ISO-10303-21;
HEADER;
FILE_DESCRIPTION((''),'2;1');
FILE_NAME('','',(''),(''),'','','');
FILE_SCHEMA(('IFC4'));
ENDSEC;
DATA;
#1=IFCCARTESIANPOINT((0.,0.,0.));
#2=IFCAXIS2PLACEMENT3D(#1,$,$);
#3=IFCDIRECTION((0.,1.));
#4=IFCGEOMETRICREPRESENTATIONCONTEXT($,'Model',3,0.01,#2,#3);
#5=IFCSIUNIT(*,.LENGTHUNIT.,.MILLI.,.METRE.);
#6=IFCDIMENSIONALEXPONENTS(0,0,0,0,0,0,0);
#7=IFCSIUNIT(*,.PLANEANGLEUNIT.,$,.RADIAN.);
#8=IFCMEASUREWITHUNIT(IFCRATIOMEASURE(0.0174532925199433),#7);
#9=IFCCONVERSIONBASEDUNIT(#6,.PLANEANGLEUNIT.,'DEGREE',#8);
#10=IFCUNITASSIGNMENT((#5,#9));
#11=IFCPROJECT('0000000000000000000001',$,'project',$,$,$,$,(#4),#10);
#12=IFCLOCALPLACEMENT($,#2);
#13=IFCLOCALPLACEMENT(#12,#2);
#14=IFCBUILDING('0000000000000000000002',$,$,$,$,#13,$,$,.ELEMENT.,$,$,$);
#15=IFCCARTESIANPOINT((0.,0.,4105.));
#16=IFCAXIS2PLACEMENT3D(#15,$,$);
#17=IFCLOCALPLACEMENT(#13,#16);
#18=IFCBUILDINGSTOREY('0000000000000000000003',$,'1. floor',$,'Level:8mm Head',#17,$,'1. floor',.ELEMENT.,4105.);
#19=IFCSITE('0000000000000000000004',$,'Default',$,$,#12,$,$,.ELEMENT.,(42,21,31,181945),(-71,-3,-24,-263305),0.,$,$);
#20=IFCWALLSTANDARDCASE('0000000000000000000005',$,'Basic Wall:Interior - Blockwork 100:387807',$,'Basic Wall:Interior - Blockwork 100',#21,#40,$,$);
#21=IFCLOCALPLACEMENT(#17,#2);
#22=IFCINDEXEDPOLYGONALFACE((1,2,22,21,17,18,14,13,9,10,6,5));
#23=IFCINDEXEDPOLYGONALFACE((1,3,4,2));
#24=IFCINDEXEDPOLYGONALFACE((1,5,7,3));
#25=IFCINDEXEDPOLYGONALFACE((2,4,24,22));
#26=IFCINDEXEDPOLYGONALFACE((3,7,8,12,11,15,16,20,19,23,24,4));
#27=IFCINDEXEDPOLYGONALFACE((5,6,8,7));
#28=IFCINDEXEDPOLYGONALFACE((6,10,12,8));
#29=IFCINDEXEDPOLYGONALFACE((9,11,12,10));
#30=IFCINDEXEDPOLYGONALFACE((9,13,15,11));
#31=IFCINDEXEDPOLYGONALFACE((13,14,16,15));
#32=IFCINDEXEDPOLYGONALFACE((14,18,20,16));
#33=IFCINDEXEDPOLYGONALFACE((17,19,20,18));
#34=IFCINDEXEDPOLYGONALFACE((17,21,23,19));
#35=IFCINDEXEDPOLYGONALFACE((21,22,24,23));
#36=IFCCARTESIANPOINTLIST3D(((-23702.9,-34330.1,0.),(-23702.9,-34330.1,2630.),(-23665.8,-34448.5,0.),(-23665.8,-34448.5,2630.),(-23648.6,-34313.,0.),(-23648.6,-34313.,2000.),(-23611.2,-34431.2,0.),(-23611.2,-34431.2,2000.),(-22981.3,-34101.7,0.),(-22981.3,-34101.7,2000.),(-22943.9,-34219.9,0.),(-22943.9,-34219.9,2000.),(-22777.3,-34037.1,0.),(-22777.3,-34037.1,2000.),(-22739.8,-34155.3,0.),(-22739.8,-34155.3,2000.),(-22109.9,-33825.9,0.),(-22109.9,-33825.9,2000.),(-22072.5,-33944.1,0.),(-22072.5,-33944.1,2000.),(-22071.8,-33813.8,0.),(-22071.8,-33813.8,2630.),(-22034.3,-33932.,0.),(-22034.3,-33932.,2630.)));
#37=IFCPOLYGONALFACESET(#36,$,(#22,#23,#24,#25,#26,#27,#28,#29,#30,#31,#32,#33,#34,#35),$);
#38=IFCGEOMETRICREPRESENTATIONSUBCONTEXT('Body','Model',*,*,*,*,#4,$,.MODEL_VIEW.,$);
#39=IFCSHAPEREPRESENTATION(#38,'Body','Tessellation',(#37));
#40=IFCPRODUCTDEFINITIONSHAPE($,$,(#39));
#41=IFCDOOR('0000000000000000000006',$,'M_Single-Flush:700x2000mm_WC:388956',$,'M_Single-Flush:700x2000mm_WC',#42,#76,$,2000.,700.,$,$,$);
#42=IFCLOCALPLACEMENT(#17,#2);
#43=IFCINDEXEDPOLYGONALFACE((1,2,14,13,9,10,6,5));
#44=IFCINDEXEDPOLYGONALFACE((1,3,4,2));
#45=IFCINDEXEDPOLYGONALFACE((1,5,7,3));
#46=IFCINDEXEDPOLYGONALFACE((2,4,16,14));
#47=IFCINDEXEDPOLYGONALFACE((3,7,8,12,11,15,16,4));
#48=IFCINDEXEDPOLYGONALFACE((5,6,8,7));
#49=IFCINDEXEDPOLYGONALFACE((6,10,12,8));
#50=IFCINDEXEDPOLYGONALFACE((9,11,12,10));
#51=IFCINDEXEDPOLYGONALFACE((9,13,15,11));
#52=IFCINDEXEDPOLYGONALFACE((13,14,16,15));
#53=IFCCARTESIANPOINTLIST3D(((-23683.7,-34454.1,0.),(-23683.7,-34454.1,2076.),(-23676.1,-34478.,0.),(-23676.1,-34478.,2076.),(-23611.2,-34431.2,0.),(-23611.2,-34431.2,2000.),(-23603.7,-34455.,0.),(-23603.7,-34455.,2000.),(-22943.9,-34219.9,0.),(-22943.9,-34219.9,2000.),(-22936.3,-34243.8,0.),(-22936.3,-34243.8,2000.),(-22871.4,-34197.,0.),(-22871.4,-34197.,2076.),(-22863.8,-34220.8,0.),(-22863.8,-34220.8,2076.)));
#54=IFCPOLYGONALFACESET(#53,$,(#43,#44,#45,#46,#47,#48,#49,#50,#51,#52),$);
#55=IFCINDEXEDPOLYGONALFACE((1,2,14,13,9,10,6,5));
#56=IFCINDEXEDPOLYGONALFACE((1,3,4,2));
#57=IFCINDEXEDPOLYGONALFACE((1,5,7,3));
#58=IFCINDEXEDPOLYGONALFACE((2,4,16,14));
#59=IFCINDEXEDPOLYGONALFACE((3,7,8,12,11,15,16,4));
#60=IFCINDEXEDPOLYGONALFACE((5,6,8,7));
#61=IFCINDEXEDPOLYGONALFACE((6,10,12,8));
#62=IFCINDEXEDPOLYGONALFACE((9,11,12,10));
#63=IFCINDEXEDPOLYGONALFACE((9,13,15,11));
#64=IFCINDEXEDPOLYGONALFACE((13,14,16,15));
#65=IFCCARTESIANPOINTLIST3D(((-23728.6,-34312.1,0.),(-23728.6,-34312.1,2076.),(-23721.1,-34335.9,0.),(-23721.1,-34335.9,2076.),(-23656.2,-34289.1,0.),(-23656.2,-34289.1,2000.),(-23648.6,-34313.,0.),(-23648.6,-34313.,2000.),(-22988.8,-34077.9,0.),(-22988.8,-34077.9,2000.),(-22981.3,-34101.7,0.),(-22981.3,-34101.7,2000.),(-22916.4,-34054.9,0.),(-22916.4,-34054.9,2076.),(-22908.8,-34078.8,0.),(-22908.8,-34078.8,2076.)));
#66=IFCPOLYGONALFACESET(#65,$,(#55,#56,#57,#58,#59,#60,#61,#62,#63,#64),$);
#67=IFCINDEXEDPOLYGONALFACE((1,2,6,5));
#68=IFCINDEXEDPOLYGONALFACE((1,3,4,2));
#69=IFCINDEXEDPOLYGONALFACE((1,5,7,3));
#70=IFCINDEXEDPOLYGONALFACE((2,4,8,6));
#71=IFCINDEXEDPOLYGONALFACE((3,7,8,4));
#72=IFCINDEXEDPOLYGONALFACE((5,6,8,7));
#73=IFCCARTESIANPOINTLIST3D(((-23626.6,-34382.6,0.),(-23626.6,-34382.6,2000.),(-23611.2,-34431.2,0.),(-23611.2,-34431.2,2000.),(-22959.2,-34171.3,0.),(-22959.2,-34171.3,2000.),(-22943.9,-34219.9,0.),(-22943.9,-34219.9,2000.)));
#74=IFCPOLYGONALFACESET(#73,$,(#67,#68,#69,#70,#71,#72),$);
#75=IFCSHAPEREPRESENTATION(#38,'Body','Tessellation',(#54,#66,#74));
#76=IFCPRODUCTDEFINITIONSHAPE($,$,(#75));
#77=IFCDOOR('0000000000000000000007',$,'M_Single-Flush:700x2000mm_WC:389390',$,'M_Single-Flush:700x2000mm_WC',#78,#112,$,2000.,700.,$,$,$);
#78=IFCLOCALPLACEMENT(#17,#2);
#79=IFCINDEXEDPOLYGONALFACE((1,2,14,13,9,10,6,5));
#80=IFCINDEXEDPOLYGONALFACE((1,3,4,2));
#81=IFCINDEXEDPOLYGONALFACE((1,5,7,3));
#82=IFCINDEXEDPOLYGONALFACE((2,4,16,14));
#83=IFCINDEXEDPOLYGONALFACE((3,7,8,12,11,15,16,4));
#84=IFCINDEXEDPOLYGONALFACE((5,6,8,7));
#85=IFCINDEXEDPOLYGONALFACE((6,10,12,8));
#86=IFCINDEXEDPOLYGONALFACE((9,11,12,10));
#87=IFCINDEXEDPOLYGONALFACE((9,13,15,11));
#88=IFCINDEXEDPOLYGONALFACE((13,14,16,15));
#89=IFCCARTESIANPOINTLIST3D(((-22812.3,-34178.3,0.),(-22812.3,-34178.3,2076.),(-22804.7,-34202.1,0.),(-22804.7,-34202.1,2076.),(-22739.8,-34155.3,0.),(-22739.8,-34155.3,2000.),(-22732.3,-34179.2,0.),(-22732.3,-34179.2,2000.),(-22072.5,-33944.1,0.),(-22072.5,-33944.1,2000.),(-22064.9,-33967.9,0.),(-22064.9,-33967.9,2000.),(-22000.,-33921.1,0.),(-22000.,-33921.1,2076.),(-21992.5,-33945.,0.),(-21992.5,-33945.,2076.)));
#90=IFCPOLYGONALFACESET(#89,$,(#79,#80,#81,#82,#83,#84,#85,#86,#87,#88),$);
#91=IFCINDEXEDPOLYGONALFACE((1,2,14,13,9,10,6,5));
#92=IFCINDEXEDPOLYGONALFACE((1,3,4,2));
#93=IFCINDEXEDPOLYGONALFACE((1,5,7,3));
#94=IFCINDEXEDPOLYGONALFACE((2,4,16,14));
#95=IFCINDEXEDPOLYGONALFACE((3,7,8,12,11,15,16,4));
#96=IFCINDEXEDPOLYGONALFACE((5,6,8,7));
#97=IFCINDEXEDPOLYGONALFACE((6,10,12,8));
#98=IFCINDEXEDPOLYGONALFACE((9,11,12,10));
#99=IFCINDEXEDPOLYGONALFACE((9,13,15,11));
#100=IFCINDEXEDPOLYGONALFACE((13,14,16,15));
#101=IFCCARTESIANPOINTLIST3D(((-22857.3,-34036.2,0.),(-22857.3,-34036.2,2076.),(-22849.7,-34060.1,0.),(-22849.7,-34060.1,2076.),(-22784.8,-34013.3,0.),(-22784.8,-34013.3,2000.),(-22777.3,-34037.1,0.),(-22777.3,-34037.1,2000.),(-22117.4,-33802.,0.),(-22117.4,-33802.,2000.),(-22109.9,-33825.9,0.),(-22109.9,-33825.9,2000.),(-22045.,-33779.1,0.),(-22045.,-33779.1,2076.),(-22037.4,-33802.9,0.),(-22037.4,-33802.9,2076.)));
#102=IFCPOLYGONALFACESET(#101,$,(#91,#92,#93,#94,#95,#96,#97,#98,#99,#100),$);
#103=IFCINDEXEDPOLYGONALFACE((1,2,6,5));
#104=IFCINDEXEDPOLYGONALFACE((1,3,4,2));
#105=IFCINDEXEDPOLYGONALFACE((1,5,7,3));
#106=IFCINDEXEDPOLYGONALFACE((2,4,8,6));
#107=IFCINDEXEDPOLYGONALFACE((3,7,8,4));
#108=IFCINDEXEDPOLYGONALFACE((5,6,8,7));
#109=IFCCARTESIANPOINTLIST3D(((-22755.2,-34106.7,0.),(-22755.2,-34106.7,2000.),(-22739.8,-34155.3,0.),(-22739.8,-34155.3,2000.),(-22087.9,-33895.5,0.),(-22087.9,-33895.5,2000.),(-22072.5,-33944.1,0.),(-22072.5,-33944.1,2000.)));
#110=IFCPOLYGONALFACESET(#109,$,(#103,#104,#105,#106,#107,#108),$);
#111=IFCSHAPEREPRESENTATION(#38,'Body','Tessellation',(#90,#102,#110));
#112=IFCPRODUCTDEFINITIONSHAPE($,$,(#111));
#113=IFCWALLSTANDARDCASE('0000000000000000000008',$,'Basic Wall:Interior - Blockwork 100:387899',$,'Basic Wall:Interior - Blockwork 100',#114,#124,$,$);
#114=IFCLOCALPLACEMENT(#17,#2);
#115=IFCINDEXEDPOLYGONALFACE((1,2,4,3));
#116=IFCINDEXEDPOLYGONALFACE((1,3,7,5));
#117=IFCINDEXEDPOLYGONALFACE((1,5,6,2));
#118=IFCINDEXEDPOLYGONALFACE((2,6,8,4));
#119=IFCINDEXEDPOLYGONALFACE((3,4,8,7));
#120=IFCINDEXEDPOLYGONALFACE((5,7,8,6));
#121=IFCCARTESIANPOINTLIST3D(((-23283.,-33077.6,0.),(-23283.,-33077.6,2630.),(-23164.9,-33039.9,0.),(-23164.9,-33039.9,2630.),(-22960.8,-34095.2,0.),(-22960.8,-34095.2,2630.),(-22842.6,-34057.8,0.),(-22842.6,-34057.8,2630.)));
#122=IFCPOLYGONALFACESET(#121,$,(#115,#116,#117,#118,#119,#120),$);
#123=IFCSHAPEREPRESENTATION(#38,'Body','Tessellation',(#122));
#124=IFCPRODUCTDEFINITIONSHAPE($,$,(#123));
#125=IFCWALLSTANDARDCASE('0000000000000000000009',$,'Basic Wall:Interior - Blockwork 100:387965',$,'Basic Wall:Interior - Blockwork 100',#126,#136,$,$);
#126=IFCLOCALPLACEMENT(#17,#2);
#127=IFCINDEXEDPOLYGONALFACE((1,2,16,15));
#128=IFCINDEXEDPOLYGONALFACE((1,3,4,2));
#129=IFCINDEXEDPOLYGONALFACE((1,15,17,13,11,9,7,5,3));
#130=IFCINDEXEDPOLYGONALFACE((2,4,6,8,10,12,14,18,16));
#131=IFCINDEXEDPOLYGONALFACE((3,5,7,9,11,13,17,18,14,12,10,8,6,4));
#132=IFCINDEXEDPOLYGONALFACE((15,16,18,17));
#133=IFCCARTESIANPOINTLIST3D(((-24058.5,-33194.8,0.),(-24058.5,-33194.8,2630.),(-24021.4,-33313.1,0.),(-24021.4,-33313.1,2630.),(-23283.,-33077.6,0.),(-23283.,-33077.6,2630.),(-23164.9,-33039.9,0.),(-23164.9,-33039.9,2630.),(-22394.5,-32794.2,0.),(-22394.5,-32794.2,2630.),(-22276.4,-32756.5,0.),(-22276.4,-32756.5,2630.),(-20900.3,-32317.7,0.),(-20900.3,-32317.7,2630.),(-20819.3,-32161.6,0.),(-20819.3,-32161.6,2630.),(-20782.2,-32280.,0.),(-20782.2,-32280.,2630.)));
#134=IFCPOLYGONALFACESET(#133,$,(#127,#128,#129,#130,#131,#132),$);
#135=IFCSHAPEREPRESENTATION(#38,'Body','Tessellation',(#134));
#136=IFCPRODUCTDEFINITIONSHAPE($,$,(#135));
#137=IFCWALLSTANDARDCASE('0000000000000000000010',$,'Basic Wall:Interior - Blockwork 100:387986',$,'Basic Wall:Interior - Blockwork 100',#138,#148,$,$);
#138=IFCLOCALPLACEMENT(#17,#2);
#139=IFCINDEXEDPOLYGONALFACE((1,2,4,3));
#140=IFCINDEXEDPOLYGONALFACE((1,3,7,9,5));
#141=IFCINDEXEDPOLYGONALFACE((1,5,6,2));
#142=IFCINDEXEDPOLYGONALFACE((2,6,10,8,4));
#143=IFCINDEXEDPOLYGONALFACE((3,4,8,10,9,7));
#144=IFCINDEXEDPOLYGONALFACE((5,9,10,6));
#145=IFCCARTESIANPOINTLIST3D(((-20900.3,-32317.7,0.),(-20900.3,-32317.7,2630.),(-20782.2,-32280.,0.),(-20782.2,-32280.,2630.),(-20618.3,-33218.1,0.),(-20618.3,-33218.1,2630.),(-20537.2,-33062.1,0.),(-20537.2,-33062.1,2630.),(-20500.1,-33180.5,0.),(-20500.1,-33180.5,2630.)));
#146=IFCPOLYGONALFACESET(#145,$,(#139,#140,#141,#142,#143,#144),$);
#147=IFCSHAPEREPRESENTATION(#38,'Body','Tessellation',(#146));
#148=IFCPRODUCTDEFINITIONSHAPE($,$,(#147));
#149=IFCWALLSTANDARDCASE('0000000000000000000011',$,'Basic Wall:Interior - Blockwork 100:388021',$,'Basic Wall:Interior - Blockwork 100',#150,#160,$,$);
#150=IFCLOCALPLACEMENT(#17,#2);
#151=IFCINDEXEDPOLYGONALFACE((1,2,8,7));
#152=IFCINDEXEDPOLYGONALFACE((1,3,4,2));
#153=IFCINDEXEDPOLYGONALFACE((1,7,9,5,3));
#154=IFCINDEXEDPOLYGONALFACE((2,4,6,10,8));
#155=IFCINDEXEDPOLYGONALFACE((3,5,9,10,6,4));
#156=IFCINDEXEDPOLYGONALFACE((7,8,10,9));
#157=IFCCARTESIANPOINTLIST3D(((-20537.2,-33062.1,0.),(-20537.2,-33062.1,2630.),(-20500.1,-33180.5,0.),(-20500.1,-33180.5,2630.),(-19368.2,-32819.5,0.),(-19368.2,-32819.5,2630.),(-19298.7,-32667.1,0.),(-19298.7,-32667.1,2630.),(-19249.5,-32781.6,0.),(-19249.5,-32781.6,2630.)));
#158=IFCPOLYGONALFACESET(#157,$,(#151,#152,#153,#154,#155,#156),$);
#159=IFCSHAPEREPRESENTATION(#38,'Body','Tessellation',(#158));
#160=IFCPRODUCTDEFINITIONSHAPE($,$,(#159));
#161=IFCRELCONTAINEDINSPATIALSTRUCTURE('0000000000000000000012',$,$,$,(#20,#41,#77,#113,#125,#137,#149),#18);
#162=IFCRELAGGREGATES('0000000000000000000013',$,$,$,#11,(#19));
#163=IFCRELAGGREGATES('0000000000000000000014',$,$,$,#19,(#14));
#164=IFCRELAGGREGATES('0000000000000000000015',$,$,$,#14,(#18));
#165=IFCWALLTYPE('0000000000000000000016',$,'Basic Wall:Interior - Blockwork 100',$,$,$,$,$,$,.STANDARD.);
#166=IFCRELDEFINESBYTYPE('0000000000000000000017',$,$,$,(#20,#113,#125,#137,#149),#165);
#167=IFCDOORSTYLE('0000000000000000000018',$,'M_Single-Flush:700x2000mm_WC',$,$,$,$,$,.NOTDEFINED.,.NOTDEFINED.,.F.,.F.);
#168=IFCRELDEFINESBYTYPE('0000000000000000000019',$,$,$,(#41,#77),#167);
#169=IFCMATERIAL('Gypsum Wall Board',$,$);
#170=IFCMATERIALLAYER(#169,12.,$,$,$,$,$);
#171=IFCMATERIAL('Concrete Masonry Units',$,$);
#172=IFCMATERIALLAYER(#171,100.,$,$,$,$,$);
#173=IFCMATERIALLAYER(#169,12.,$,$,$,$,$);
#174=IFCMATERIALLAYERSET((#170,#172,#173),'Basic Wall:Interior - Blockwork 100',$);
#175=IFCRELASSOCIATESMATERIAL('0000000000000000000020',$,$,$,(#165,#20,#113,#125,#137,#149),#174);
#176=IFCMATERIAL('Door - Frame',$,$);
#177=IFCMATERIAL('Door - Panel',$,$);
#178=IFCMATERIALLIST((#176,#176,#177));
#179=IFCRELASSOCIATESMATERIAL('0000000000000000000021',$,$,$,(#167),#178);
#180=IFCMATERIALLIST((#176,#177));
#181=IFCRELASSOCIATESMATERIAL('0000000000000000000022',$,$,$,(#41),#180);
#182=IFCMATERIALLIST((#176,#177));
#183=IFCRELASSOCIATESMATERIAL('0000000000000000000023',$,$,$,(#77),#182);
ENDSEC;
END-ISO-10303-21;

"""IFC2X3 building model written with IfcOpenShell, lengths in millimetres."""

from ifc_helpers import new_model, entity, si_unit, converted_unit, direction, frame, frame_2d, origin, origin_2d_with_axis, place, context, subcontext, project, spatial, polyline, rectangle, outline, extrude, source, transform, mapped, material, material_list, layer, layer_set, layer_usage, type_object, type_shapes, element, fill, save


model = new_model("IFC2X3")

# Units and contexts
model_context = context("Model", 3, precision=0.01, world=origin(), true_north=direction((0.0, 1.0)))
body_context = subcontext(model_context, "Body", "Model", "MODEL_VIEW")
ifc_project = project(units=[si_unit("LENGTHUNIT", "METRE", prefix="MILLI"), converted_unit("PLANEANGLEUNIT", "DEGREE", entity("IfcRatioMeasure", 0.0174532925199433), si_unit("PLANEANGLEUNIT", "RADIAN"), dimensions=[0, 0, 0, 0, 0, 0, 0])], contexts=[model_context])

# Site, building, storey
site_placement = place(None, origin())
site = spatial("IfcSite", under=ifc_project, at=site_placement, Name="Default", CompositionType="ELEMENT", RefLatitude=(42, 21, 31, 181945), RefLongitude=(-71, -3, -24, -263305), RefElevation=0.0)
building_placement = place(site_placement, origin())
building = spatial("IfcBuilding", under=site, at=building_placement, CompositionType="ELEMENT")
storey_placement = place(building_placement, frame((0.0, 0.0, 4105.0)))
storey = spatial("IfcBuildingStorey", under=building, at=storey_placement, Name="1. floor", ObjectType="Level:8mm Head", LongName="1. floor", CompositionType="ELEMENT", Elevation=4105.0)

# Shared definitions
ifc_material_1 = material(Name="Gypsum Wall Board")
ifc_layer_1 = layer(ifc_material_1, 12.0)
ifc_material_2 = material(Name="Concrete Masonry Units")
ifc_layer_2 = layer(ifc_material_2, 100.0)
ifc_layer_3 = layer(ifc_material_1, 12.0)
ifc_layer_set = layer_set([ifc_layer_1, ifc_layer_2, ifc_layer_3], Name="Basic Wall:Interior - Blockwork 100")
wall_type = type_object("IfcWallType", Name="Basic Wall:Interior - Blockwork 100", PredefinedType="STANDARD", material=ifc_layer_set)
ifc_material_3 = material(Name="Door - Frame")
ifc_material_4 = material(Name="Door - Panel")
ifc_material_list_1 = material_list([ifc_material_3, ifc_material_3, ifc_material_4])
door_style_1 = type_object("IfcDoorStyle", Name="M_Single-Flush:700x2000mm_WC", ConstructionType="NOTDEFINED", OperationType="NOTDEFINED", ParameterTakesPrecedence=False, Sizeable=False, material=ifc_material_list_1)
shared_shape_1 = source(origin(), body_context, "Body", "SweptSolid", [
    extrude(outline(polyline([(-426.0, -1057.0), (426.0, -1057.0), (426.0, 1019.0), (350.0, 1019.0), (350.0, -981.0), (-350.0, -981.0), (-350.0, 1019.0), (-426.0, 1019.0), (-426.0, -1057.0)])), frame((350.0, 124.0, 1019.0), z_axis=(0.0, 1.0, 0.0), x_axis=(1.0, 0.0, 0.0)), (0.0, 0.0, 1.0), 25.0),
    extrude(outline(polyline([(-1057.0, -426.0), (1019.0, -426.0), (1019.0, -350.0), (-981.0, -350.0), (-981.0, 350.0), (1019.0, 350.0), (1019.0, 426.0), (-1057.0, 426.0), (-1057.0, -426.0)])), frame((350.0, -25.0, 1019.0), z_axis=(0.0, 1.0, 0.0), x_axis=(0.0, 0.0, -1.0)), (0.0, 0.0, 1.0), 25.0),
    extrude(rectangle(XDim=51.0, YDim=700.0, at=origin_2d_with_axis()), frame((350.0, 98.5, 0.0), z_axis=(0.0, 0.0, 1.0), x_axis=(0.0, 1.0, 0.0)), (0.0, 0.0, 1.0), 2000.0),
])
type_shapes(door_style_1, [shared_shape_1])

# Wall, openings, doors
ifc_layer_usage_1 = layer_usage(ifc_layer_set, "AXIS2", "NEGATIVE", 62.0)
wall_1_placement = place(storey_placement, frame((-23684.5, -34389.4, 0.0), z_axis=(0.0, 0.0, 1.0), x_axis=(0.953372, 0.301797, 0.0)))
wall_1 = element("IfcWallStandardCase", 1, at=wall_1_placement, inside=storey, type_object=wall_type, material=ifc_layer_usage_1, Name="Basic Wall:Interior - Blockwork 100:387807", ObjectType="Basic Wall:Interior - Blockwork 100", context=body_context, shape_type="SweptSolid", body=[
    extrude(outline(polyline([(0.0, -62.0), (1711.2, -62.0), (1711.2, 62.0), (902.7, 62.0), (778.7, 62.0), (0.4, 62.0), (0.0, -62.0)])), origin(), (0.0, 0.0, 1.0), 2630.0),
])
opening_1_placement = place(wall_1_placement, frame((757.2, 62.0, 0.0)))
opening_1 = element("IfcOpeningElement", 2, at=opening_1_placement, cuts=wall_1, ObjectType="Opening", context=body_context, shape_type="SweptSolid", body=[
    extrude(rectangle(XDim=700.0, YDim=2000.0, at=frame_2d((1000.0, 350.0), x_axis=(0.0, 1.0))), frame((0.0, 0.0, 0.0), z_axis=(0.0, -1.0, 0.0), x_axis=(0.0, 0.0, 1.0)), (0.0, 0.0, 1.0), 124.0),
])
opening_2_placement = place(wall_1_placement, frame((1671.2, 62.0, 0.0)))
opening_2 = element("IfcOpeningElement", 3, at=opening_2_placement, cuts=wall_1, ObjectType="Opening", context=body_context, shape_type="SweptSolid", body=[
    extrude(rectangle(XDim=700.0, YDim=2000.0, at=frame_2d((1000.0, 350.0), x_axis=(0.0, 1.0))), frame((0.0, 0.0, 0.0), z_axis=(0.0, -1.0, 0.0), x_axis=(0.0, 0.0, 1.0)), (0.0, 0.0, 1.0), 124.0),
])
ifc_material_list_2 = material_list([ifc_material_3, ifc_material_4])
door_1_placement = place(opening_1_placement, frame((0.0, 0.0, 0.0), z_axis=(0.0, 0.0, 1.0), x_axis=(-1.0, 0.0, 0.0)))
door_1 = element("IfcDoor", 4, at=door_1_placement, inside=storey, type_object=door_style_1, material=ifc_material_list_2, Name="M_Single-Flush:700x2000mm_WC:388956", ObjectType="M_Single-Flush:700x2000mm_WC", OverallHeight=2000.0, OverallWidth=700.0, context=body_context, shape_type="MappedRepresentation", body=[
    mapped(shared_shape_1, transform((0.0, 0.0, 0.0), scale=1.0)),
])
fill(opening_1, door_1)
ifc_material_list_3 = material_list([ifc_material_3, ifc_material_4])
door_2_placement = place(opening_2_placement, frame((0.0, 0.0, 0.0), z_axis=(0.0, 0.0, 1.0), x_axis=(-1.0, 0.0, 0.0)))
door_2 = element("IfcDoor", 5, at=door_2_placement, inside=storey, type_object=door_style_1, material=ifc_material_list_3, Name="M_Single-Flush:700x2000mm_WC:389390", ObjectType="M_Single-Flush:700x2000mm_WC", OverallHeight=2000.0, OverallWidth=700.0, context=body_context, shape_type="MappedRepresentation", body=[
    mapped(shared_shape_1, transform((0.0, 0.0, 0.0), scale=1.0)),
])
fill(opening_2, door_2)

# Walls
ifc_layer_usage_2 = layer_usage(ifc_layer_set, "AXIS2", "NEGATIVE", 62.0)
wall_2_placement = place(storey_placement, frame((-23224.0, -33058.6, 0.0), z_axis=(0.0, 0.0, 1.0), x_axis=(0.301797, -0.953372, 0.0)))
element("IfcWallStandardCase", 6, at=wall_2_placement, inside=storey, type_object=wall_type, material=ifc_layer_usage_2, Name="Basic Wall:Interior - Blockwork 100:387899", ObjectType="Basic Wall:Interior - Blockwork 100", context=body_context, shape_type="SweptSolid", body=[
    extrude(outline(polyline([(1067.7, -62.0), (1067.7, 62.0), (0.0, 62.0), (0.3, -62.0), (1067.7, -62.0)])), origin(), (0.0, 0.0, 1.0), 2630.0),
])
ifc_layer_usage_3 = layer_usage(ifc_layer_set, "AXIS2", "NEGATIVE", 62.0)
wall_3_placement = place(storey_placement, frame((-24040.3, -33254.0, 0.0), z_axis=(0.0, 0.0, 1.0), x_axis=(0.952718, 0.303856, 0.0)))
element("IfcWallStandardCase", 7, at=wall_3_placement, inside=storey, type_object=wall_type, material=ifc_layer_usage_3, Name="Basic Wall:Interior - Blockwork 100:387965", ObjectType="Basic Wall:Interior - Blockwork 100", context=body_context, shape_type="SweptSolid", body=[
    extrude(outline(polyline([(3400.0, -62.0), (3400.6, 62.0), (0.6, 62.0), (0.0, -62.0), (775.1, -62.0), (899.1, -62.0), (1707.7, -62.0), (1831.7, -62.0), (3276.0, -62.0), (3400.0, -62.0)])), origin(), (0.0, 0.0, 1.0), 2630.0),
])
ifc_layer_usage_4 = layer_usage(ifc_layer_set, "AXIS2", "NEGATIVE", 62.0)
wall_4_placement = place(storey_placement, frame((-20841.4, -32298.5, 0.0), z_axis=(0.0, 0.0, 1.0), x_axis=(0.298924, -0.954277, 0.0)))
element("IfcWallStandardCase", 8, at=wall_4_placement, inside=storey, type_object=wall_type, material=ifc_layer_usage_4, Name="Basic Wall:Interior - Blockwork 100:387986", ObjectType="Basic Wall:Interior - Blockwork 100", context=body_context, shape_type="SweptSolid", body=[
    extrude(outline(polyline([(944.3, -62.0), (943.6, 62.0), (819.6, 62.0), (0.0, 62.0), (0.6, -62.0), (944.3, -62.0)])), origin(), (0.0, 0.0, 1.0), 2630.0),
])
ifc_layer_usage_5 = layer_usage(ifc_layer_set, "AXIS2", "NEGATIVE", 62.0)
wall_5_placement = place(storey_placement, frame((-20519.0, -33121.4, 0.0), z_axis=(0.0, 0.0, 1.0), x_axis=(0.952718, 0.303856, 0.0)))
element("IfcWallStandardCase", 9, at=wall_5_placement, inside=storey, type_object=wall_type, material=ifc_layer_usage_5, Name="Basic Wall:Interior - Blockwork 100:388021", ObjectType="Basic Wall:Interior - Blockwork 100", context=body_context, shape_type="SweptSolid", body=[
    extrude(outline(polyline([(1312.6, -62.0), (1300.6, 62.0), (0.6, 62.0), (0.0, -62.0), (1188.1, -62.0), (1312.6, -62.0)])), origin(), (0.0, 0.0, 1.0), 2630.0),
])

save(model, "model.ifc")
